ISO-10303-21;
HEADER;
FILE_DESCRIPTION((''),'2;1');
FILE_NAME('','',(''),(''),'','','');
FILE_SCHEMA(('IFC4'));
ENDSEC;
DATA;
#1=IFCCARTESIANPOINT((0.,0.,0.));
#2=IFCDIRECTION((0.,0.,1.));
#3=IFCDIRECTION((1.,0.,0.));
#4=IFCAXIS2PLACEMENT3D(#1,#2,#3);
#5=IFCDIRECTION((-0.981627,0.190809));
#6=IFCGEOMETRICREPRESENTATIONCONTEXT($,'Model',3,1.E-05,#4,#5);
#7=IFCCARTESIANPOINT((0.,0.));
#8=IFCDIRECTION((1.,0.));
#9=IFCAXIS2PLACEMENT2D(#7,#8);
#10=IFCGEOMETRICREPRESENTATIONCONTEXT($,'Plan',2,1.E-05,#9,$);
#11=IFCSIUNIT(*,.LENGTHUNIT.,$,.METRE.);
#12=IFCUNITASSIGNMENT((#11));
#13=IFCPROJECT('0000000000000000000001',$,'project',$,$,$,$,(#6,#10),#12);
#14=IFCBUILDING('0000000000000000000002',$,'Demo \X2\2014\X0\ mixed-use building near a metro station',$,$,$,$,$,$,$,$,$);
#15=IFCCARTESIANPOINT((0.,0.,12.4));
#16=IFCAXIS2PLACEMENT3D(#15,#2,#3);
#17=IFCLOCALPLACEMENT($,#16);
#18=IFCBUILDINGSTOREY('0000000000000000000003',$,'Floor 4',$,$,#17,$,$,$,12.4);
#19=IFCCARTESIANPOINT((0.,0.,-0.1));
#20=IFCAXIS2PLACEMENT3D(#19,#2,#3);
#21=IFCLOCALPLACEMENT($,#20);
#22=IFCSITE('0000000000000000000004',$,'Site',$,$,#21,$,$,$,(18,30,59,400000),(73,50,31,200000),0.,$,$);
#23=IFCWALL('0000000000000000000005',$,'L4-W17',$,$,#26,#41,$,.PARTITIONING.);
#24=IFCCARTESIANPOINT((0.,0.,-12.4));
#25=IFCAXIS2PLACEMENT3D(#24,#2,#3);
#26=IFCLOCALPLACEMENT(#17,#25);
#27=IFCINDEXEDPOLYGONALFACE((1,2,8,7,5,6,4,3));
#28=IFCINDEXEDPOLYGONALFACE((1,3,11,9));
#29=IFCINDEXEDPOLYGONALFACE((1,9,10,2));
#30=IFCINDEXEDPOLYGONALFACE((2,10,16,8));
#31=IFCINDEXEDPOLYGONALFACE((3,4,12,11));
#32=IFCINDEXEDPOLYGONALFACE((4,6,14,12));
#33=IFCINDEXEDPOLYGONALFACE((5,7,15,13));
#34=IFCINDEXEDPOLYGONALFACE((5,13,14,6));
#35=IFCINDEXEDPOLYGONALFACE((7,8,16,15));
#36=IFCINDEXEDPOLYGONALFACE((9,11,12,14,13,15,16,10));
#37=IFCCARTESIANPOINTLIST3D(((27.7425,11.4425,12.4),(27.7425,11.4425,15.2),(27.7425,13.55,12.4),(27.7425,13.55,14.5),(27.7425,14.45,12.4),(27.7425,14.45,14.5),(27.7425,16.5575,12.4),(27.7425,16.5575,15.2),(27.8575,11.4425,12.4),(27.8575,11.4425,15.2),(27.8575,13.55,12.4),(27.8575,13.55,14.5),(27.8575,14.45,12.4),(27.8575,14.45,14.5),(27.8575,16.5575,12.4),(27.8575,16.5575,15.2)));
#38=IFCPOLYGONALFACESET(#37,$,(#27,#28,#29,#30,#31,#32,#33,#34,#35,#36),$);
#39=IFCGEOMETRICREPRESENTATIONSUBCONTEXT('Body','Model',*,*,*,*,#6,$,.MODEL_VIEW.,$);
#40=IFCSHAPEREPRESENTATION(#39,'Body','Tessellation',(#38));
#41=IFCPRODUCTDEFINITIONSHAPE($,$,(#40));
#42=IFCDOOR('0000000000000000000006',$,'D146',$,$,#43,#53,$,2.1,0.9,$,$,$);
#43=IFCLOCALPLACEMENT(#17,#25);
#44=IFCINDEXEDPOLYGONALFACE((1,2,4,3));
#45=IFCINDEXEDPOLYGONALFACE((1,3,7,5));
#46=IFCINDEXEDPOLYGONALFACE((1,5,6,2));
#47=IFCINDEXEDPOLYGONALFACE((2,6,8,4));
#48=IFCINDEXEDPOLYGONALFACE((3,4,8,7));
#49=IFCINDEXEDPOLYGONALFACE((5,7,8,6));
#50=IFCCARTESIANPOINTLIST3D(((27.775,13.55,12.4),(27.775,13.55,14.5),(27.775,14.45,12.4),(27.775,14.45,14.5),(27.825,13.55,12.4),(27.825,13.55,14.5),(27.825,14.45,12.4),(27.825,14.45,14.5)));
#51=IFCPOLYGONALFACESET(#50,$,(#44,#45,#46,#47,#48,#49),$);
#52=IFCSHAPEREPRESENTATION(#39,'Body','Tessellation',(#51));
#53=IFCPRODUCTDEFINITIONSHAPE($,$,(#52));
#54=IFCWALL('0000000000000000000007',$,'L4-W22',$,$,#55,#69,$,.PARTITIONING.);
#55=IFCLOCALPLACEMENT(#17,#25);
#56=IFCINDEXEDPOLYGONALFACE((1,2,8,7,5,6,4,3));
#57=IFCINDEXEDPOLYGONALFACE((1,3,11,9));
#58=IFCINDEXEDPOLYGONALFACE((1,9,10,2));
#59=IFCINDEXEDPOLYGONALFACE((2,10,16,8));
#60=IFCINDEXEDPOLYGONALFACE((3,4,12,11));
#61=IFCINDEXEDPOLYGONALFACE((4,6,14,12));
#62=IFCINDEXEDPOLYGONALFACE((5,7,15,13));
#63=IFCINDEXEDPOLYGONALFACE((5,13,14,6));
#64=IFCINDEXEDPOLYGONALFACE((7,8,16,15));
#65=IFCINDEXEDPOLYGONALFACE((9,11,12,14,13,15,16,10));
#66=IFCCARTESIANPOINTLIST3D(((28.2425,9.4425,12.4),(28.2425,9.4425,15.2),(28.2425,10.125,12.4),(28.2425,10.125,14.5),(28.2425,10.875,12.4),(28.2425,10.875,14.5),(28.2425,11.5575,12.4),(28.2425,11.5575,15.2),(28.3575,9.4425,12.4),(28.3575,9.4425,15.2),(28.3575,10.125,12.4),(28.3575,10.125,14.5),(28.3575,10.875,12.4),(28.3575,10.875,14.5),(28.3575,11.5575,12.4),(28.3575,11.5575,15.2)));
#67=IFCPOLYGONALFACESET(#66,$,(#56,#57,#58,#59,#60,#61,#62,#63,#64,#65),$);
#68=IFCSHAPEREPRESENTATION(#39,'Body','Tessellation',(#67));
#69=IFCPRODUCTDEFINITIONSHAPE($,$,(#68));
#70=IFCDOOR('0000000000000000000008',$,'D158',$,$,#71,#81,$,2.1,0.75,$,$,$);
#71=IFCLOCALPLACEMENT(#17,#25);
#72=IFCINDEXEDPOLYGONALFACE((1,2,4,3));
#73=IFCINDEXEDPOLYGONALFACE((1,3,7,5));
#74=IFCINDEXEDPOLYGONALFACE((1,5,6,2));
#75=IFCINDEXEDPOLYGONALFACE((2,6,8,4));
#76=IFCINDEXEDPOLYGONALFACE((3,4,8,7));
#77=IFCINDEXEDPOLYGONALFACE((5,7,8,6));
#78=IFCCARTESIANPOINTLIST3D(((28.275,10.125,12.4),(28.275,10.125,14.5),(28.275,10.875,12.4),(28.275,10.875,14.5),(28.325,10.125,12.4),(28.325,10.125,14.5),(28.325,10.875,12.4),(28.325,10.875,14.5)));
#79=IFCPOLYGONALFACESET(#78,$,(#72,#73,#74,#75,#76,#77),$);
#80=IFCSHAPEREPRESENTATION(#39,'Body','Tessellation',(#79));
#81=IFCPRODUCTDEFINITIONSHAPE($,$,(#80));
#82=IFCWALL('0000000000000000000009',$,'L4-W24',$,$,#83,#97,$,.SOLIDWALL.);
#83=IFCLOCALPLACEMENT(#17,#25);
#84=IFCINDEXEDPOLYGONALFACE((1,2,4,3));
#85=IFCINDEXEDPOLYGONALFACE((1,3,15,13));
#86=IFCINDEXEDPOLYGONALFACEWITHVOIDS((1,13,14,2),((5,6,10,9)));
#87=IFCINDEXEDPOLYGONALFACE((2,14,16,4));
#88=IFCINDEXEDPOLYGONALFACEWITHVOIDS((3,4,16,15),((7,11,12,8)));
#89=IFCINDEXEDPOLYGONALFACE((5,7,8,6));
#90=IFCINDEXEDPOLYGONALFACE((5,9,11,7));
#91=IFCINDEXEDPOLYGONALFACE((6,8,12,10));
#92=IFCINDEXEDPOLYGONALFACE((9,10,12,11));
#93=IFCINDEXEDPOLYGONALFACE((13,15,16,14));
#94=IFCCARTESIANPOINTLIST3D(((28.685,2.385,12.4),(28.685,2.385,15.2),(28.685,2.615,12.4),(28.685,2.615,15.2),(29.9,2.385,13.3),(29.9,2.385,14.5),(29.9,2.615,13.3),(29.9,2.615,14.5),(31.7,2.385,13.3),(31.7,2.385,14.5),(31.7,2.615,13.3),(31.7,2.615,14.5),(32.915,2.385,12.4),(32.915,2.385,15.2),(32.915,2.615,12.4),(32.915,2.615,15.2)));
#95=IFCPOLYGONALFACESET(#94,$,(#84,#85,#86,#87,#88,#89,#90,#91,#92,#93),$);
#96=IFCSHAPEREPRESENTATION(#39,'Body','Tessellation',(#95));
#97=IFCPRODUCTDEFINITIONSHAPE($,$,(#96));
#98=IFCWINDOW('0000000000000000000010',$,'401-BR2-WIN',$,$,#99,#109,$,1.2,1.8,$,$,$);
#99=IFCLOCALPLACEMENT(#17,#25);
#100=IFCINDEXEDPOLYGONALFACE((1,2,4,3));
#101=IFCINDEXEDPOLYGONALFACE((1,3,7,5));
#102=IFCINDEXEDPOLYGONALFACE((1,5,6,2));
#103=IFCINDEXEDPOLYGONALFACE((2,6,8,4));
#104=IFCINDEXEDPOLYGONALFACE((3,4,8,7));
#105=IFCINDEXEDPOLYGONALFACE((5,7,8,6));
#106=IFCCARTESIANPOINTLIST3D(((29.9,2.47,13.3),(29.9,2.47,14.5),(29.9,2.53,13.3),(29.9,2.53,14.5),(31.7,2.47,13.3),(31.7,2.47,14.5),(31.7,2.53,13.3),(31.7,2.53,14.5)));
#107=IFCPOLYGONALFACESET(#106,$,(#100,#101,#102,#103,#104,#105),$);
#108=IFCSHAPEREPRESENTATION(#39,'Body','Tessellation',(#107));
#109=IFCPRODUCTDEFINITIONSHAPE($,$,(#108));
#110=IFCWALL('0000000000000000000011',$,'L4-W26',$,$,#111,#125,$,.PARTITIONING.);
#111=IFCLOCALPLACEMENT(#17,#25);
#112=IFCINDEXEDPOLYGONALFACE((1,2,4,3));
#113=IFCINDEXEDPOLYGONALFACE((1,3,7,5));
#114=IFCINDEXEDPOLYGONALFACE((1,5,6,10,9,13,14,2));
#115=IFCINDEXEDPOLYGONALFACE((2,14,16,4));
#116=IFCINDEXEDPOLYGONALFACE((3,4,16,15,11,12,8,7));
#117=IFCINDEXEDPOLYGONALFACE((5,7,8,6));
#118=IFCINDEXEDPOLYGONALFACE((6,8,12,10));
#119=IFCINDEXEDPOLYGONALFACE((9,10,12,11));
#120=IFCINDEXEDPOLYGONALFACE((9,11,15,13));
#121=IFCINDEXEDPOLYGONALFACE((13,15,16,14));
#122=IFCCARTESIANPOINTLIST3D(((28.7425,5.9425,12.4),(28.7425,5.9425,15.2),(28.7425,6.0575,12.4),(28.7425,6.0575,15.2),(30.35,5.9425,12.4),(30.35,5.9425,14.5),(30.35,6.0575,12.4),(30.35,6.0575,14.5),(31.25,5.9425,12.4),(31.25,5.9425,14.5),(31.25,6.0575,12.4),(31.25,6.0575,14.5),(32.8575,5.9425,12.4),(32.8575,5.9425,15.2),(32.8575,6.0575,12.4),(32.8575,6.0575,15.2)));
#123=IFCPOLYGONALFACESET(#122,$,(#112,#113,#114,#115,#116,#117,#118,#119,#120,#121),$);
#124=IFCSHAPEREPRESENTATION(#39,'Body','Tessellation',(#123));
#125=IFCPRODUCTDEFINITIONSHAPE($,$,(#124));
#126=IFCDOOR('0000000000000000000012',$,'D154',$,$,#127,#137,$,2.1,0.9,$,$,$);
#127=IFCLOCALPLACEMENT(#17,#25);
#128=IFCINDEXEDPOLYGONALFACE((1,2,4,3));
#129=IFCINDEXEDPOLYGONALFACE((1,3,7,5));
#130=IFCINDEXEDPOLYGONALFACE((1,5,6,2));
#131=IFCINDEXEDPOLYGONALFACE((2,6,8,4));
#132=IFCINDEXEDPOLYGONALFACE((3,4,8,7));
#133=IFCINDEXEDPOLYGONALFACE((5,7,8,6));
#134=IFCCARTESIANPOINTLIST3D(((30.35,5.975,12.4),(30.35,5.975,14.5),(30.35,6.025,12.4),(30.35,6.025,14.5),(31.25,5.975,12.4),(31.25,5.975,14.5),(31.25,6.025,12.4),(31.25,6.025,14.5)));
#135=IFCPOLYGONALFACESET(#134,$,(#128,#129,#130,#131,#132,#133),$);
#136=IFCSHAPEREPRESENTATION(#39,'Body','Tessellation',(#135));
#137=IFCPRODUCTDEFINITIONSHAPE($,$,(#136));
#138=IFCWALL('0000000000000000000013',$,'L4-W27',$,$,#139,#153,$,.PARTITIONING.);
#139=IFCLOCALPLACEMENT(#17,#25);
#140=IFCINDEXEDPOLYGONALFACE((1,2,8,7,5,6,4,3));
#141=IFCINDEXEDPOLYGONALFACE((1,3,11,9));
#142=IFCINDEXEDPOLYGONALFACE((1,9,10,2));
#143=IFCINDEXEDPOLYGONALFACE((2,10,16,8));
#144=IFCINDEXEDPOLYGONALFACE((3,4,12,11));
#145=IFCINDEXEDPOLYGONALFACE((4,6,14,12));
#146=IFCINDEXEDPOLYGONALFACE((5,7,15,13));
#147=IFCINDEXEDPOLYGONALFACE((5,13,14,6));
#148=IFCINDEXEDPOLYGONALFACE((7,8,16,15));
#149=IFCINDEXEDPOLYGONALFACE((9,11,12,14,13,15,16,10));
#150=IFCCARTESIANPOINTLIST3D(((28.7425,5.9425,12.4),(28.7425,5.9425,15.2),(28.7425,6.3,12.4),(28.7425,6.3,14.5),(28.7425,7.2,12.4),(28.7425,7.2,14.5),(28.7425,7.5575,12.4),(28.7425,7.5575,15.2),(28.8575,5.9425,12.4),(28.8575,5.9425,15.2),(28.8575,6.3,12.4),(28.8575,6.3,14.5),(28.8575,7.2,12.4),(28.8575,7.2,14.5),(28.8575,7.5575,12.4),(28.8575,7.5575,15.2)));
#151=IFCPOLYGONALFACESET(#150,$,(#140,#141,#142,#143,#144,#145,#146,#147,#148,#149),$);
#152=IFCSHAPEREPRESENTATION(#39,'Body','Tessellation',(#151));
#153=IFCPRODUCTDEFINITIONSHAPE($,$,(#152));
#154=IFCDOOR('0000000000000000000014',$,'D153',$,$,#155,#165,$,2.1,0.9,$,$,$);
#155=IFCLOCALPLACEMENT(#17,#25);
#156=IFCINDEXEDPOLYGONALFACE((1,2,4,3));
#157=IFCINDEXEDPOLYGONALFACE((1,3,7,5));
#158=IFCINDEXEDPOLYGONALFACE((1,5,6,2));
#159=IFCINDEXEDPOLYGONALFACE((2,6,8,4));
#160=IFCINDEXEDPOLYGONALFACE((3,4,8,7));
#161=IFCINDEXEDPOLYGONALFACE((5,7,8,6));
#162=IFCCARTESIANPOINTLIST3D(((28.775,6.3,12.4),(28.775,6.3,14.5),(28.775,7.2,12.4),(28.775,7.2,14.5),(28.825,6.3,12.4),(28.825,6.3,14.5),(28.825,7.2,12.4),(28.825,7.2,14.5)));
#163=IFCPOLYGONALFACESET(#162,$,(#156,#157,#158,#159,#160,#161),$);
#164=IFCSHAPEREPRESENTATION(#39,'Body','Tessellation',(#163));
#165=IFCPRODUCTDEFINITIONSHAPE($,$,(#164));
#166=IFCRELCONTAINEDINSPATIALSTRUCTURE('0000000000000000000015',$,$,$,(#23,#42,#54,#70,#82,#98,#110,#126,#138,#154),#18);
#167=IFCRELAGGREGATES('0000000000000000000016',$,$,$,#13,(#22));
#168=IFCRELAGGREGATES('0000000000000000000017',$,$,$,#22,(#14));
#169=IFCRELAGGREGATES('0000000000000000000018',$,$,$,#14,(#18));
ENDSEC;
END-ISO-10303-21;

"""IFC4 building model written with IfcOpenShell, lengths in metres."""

from ifc_helpers import new_model, si_unit, direction, frame, origin_with_axes, origin_2d_with_axis, place, context, subcontext, project, spatial, line, indexed_curve, outline, extrude, element, fill, save


model = new_model("IFC4")

# Units and contexts
model_context = context("Model", 3, precision=1e-05, world=origin_with_axes(), true_north=direction((-0.981627, 0.190809)))
plan_context = context("Plan", 2, precision=1e-05, world=origin_2d_with_axis())
body_context = subcontext(model_context, "Body", "Model", "MODEL_VIEW")
ifc_project = project(units=[si_unit("LENGTHUNIT", "METRE")], contexts=[model_context, plan_context])

# Site, building, storey
site_placement = place(None, frame((0.0, 0.0, -0.1), z_axis=(0.0, 0.0, 1.0), x_axis=(1.0, 0.0, 0.0)))
site = spatial("IfcSite", under=ifc_project, at=site_placement, Name="Site", RefLatitude=(18, 30, 59, 400000), RefLongitude=(73, 50, 31, 200000), RefElevation=0.0)
building = spatial("IfcBuilding", under=site, Name="Demo — mixed-use building near a metro station")
storey_placement = place(None, frame((0.0, 0.0, 12.4), z_axis=(0.0, 0.0, 1.0), x_axis=(1.0, 0.0, 0.0)))
storey = spatial("IfcBuildingStorey", under=building, at=storey_placement, Name="Floor 4", Elevation=12.4)

# Wall, opening, door
wall_1_placement = place(storey_placement, frame((0.0, 0.0, -12.4), z_axis=(0.0, 0.0, 1.0), x_axis=(1.0, 0.0, 0.0)))
wall_1 = element("IfcWall", 1, at=wall_1_placement, inside=storey, Name="L4-W17", PredefinedType="PARTITIONING", context=body_context, shape_type="SweptSolid", body=[
    extrude(outline(indexed_curve([(27.7425, 11.4425), (27.7425, 16.5575), (27.8575, 16.5575), (27.8575, 11.4425)], segments=[line(1, 2, 3, 4, 1)])), frame((0.0, 0.0, 12.4), z_axis=(0.0, 0.0, 1.0), x_axis=(1.0, 0.0, 0.0)), (0.0, 0.0, 1.0), 2.8),
])
opening_1_placement = place(wall_1_placement, origin_with_axes())
opening_1 = element("IfcOpeningElement", 2, at=opening_1_placement, cuts=wall_1, context=body_context, shape_type="SweptSolid", body=[
    extrude(outline(indexed_curve([(27.6925, 13.55), (27.6925, 14.45), (27.9075, 14.45), (27.9075, 13.55)], segments=[line(1, 2, 3, 4, 1)])), frame((0.0, 0.0, 12.4), z_axis=(0.0, 0.0, 1.0), x_axis=(1.0, 0.0, 0.0)), (0.0, 0.0, 1.0), 2.1),
])
door_1_placement = place(storey_placement, frame((0.0, 0.0, -12.4), z_axis=(0.0, 0.0, 1.0), x_axis=(1.0, 0.0, 0.0)))
door_1 = element("IfcDoor", 3, at=door_1_placement, inside=storey, Name="D146", OverallHeight=2.1, OverallWidth=0.9, context=body_context, shape_type="SweptSolid", body=[
    extrude(outline(indexed_curve([(27.775, 13.55), (27.775, 14.45), (27.825, 14.45), (27.825, 13.55)], segments=[line(1, 2, 3, 4, 1)])), frame((0.0, 0.0, 12.4), z_axis=(0.0, 0.0, 1.0), x_axis=(1.0, 0.0, 0.0)), (0.0, 0.0, 1.0), 2.1),
])
fill(opening_1, door_1)

# Wall, opening, door
wall_2_placement = place(storey_placement, frame((0.0, 0.0, -12.4), z_axis=(0.0, 0.0, 1.0), x_axis=(1.0, 0.0, 0.0)))
wall_2 = element("IfcWall", 4, at=wall_2_placement, inside=storey, Name="L4-W22", PredefinedType="PARTITIONING", context=body_context, shape_type="SweptSolid", body=[
    extrude(outline(indexed_curve([(28.2425, 9.4425), (28.2425, 11.5575), (28.3575, 11.5575), (28.3575, 9.4425)], segments=[line(1, 2, 3, 4, 1)])), frame((0.0, 0.0, 12.4), z_axis=(0.0, 0.0, 1.0), x_axis=(1.0, 0.0, 0.0)), (0.0, 0.0, 1.0), 2.8),
])
opening_2_placement = place(wall_2_placement, origin_with_axes())
opening_2 = element("IfcOpeningElement", 5, at=opening_2_placement, cuts=wall_2, context=body_context, shape_type="SweptSolid", body=[
    extrude(outline(indexed_curve([(28.1925, 10.125), (28.1925, 10.875), (28.4075, 10.875), (28.4075, 10.125)], segments=[line(1, 2, 3, 4, 1)])), frame((0.0, 0.0, 12.4), z_axis=(0.0, 0.0, 1.0), x_axis=(1.0, 0.0, 0.0)), (0.0, 0.0, 1.0), 2.1),
])
door_2_placement = place(storey_placement, frame((0.0, 0.0, -12.4), z_axis=(0.0, 0.0, 1.0), x_axis=(1.0, 0.0, 0.0)))
door_2 = element("IfcDoor", 6, at=door_2_placement, inside=storey, Name="D158", OverallHeight=2.1, OverallWidth=0.75, context=body_context, shape_type="SweptSolid", body=[
    extrude(outline(indexed_curve([(28.275, 10.125), (28.275, 10.875), (28.325, 10.875), (28.325, 10.125)], segments=[line(1, 2, 3, 4, 1)])), frame((0.0, 0.0, 12.4), z_axis=(0.0, 0.0, 1.0), x_axis=(1.0, 0.0, 0.0)), (0.0, 0.0, 1.0), 2.1),
])
fill(opening_2, door_2)

# Wall, opening, window
wall_3_placement = place(storey_placement, frame((0.0, 0.0, -12.4), z_axis=(0.0, 0.0, 1.0), x_axis=(1.0, 0.0, 0.0)))
wall_3 = element("IfcWall", 7, at=wall_3_placement, inside=storey, Name="L4-W24", PredefinedType="SOLIDWALL", context=body_context, shape_type="SweptSolid", body=[
    extrude(outline(indexed_curve([(28.685, 2.615), (32.915, 2.615), (32.915, 2.385), (28.685, 2.385)], segments=[line(1, 2, 3, 4, 1)])), frame((0.0, 0.0, 12.4), z_axis=(0.0, 0.0, 1.0), x_axis=(1.0, 0.0, 0.0)), (0.0, 0.0, 1.0), 2.8),
])
opening_3_placement = place(wall_3_placement, origin_with_axes())
opening_3 = element("IfcOpeningElement", 8, at=opening_3_placement, cuts=wall_3, context=body_context, shape_type="SweptSolid", body=[
    extrude(outline(indexed_curve([(29.9, 2.665), (31.7, 2.665), (31.7, 2.335), (29.9, 2.335)], segments=[line(1, 2, 3, 4, 1)])), frame((0.0, 0.0, 13.3), z_axis=(0.0, 0.0, 1.0), x_axis=(1.0, 0.0, 0.0)), (0.0, 0.0, 1.0), 1.2),
])
window_placement = place(storey_placement, frame((0.0, 0.0, -12.4), z_axis=(0.0, 0.0, 1.0), x_axis=(1.0, 0.0, 0.0)))
window = element("IfcWindow", 9, at=window_placement, inside=storey, Name="401-BR2-WIN", OverallHeight=1.2, OverallWidth=1.8, context=body_context, shape_type="SweptSolid", body=[
    extrude(outline(indexed_curve([(29.9, 2.53), (31.7, 2.53), (31.7, 2.47), (29.9, 2.47)], segments=[line(1, 2, 3, 4, 1)])), frame((0.0, 0.0, 13.3), z_axis=(0.0, 0.0, 1.0), x_axis=(1.0, 0.0, 0.0)), (0.0, 0.0, 1.0), 1.2),
])
fill(opening_3, window)

# Walls, openings, doors
wall_4_placement = place(storey_placement, frame((0.0, 0.0, -12.4), z_axis=(0.0, 0.0, 1.0), x_axis=(1.0, 0.0, 0.0)))
wall_4 = element("IfcWall", 10, at=wall_4_placement, inside=storey, Name="L4-W26", PredefinedType="PARTITIONING", context=body_context, shape_type="SweptSolid", body=[
    extrude(outline(indexed_curve([(32.8575, 5.9425), (28.7425, 5.9425), (28.7425, 6.0575), (32.8575, 6.0575)], segments=[line(1, 2, 3, 4, 1)])), frame((0.0, 0.0, 12.4), z_axis=(0.0, 0.0, 1.0), x_axis=(1.0, 0.0, 0.0)), (0.0, 0.0, 1.0), 2.8),
])
opening_4_placement = place(wall_4_placement, origin_with_axes())
opening_4 = element("IfcOpeningElement", 11, at=opening_4_placement, cuts=wall_4, context=body_context, shape_type="SweptSolid", body=[
    extrude(outline(indexed_curve([(31.25, 5.8925), (30.35, 5.8925), (30.35, 6.1075), (31.25, 6.1075)], segments=[line(1, 2, 3, 4, 1)])), frame((0.0, 0.0, 12.4), z_axis=(0.0, 0.0, 1.0), x_axis=(1.0, 0.0, 0.0)), (0.0, 0.0, 1.0), 2.1),
])
door_3_placement = place(storey_placement, frame((0.0, 0.0, -12.4), z_axis=(0.0, 0.0, 1.0), x_axis=(1.0, 0.0, 0.0)))
door_3 = element("IfcDoor", 12, at=door_3_placement, inside=storey, Name="D154", OverallHeight=2.1, OverallWidth=0.9, context=body_context, shape_type="SweptSolid", body=[
    extrude(outline(indexed_curve([(31.25, 5.975), (30.35, 5.975), (30.35, 6.025), (31.25, 6.025)], segments=[line(1, 2, 3, 4, 1)])), frame((0.0, 0.0, 12.4), z_axis=(0.0, 0.0, 1.0), x_axis=(1.0, 0.0, 0.0)), (0.0, 0.0, 1.0), 2.1),
])
fill(opening_4, door_3)
wall_5_placement = place(storey_placement, frame((0.0, 0.0, -12.4), z_axis=(0.0, 0.0, 1.0), x_axis=(1.0, 0.0, 0.0)))
wall_5 = element("IfcWall", 13, at=wall_5_placement, inside=storey, Name="L4-W27", PredefinedType="PARTITIONING", context=body_context, shape_type="SweptSolid", body=[
    extrude(outline(indexed_curve([(28.7425, 5.9425), (28.7425, 7.5575), (28.8575, 7.5575), (28.8575, 5.9425)], segments=[line(1, 2, 3, 4, 1)])), frame((0.0, 0.0, 12.4), z_axis=(0.0, 0.0, 1.0), x_axis=(1.0, 0.0, 0.0)), (0.0, 0.0, 1.0), 2.8),
])
opening_5_placement = place(wall_5_placement, origin_with_axes())
opening_5 = element("IfcOpeningElement", 14, at=opening_5_placement, cuts=wall_5, context=body_context, shape_type="SweptSolid", body=[
    extrude(outline(indexed_curve([(28.6925, 6.3), (28.6925, 7.2), (28.9075, 7.2), (28.9075, 6.3)], segments=[line(1, 2, 3, 4, 1)])), frame((0.0, 0.0, 12.4), z_axis=(0.0, 0.0, 1.0), x_axis=(1.0, 0.0, 0.0)), (0.0, 0.0, 1.0), 2.1),
])
door_4_placement = place(storey_placement, frame((0.0, 0.0, -12.4), z_axis=(0.0, 0.0, 1.0), x_axis=(1.0, 0.0, 0.0)))
door_4 = element("IfcDoor", 15, at=door_4_placement, inside=storey, Name="D153", OverallHeight=2.1, OverallWidth=0.9, context=body_context, shape_type="SweptSolid", body=[
    extrude(outline(indexed_curve([(28.775, 6.3), (28.775, 7.2), (28.825, 7.2), (28.825, 6.3)], segments=[line(1, 2, 3, 4, 1)])), frame((0.0, 0.0, 12.4), z_axis=(0.0, 0.0, 1.0), x_axis=(1.0, 0.0, 0.0)), (0.0, 0.0, 1.0), 2.1),
])
fill(opening_5, door_4)

save(model, "model.ifc")
